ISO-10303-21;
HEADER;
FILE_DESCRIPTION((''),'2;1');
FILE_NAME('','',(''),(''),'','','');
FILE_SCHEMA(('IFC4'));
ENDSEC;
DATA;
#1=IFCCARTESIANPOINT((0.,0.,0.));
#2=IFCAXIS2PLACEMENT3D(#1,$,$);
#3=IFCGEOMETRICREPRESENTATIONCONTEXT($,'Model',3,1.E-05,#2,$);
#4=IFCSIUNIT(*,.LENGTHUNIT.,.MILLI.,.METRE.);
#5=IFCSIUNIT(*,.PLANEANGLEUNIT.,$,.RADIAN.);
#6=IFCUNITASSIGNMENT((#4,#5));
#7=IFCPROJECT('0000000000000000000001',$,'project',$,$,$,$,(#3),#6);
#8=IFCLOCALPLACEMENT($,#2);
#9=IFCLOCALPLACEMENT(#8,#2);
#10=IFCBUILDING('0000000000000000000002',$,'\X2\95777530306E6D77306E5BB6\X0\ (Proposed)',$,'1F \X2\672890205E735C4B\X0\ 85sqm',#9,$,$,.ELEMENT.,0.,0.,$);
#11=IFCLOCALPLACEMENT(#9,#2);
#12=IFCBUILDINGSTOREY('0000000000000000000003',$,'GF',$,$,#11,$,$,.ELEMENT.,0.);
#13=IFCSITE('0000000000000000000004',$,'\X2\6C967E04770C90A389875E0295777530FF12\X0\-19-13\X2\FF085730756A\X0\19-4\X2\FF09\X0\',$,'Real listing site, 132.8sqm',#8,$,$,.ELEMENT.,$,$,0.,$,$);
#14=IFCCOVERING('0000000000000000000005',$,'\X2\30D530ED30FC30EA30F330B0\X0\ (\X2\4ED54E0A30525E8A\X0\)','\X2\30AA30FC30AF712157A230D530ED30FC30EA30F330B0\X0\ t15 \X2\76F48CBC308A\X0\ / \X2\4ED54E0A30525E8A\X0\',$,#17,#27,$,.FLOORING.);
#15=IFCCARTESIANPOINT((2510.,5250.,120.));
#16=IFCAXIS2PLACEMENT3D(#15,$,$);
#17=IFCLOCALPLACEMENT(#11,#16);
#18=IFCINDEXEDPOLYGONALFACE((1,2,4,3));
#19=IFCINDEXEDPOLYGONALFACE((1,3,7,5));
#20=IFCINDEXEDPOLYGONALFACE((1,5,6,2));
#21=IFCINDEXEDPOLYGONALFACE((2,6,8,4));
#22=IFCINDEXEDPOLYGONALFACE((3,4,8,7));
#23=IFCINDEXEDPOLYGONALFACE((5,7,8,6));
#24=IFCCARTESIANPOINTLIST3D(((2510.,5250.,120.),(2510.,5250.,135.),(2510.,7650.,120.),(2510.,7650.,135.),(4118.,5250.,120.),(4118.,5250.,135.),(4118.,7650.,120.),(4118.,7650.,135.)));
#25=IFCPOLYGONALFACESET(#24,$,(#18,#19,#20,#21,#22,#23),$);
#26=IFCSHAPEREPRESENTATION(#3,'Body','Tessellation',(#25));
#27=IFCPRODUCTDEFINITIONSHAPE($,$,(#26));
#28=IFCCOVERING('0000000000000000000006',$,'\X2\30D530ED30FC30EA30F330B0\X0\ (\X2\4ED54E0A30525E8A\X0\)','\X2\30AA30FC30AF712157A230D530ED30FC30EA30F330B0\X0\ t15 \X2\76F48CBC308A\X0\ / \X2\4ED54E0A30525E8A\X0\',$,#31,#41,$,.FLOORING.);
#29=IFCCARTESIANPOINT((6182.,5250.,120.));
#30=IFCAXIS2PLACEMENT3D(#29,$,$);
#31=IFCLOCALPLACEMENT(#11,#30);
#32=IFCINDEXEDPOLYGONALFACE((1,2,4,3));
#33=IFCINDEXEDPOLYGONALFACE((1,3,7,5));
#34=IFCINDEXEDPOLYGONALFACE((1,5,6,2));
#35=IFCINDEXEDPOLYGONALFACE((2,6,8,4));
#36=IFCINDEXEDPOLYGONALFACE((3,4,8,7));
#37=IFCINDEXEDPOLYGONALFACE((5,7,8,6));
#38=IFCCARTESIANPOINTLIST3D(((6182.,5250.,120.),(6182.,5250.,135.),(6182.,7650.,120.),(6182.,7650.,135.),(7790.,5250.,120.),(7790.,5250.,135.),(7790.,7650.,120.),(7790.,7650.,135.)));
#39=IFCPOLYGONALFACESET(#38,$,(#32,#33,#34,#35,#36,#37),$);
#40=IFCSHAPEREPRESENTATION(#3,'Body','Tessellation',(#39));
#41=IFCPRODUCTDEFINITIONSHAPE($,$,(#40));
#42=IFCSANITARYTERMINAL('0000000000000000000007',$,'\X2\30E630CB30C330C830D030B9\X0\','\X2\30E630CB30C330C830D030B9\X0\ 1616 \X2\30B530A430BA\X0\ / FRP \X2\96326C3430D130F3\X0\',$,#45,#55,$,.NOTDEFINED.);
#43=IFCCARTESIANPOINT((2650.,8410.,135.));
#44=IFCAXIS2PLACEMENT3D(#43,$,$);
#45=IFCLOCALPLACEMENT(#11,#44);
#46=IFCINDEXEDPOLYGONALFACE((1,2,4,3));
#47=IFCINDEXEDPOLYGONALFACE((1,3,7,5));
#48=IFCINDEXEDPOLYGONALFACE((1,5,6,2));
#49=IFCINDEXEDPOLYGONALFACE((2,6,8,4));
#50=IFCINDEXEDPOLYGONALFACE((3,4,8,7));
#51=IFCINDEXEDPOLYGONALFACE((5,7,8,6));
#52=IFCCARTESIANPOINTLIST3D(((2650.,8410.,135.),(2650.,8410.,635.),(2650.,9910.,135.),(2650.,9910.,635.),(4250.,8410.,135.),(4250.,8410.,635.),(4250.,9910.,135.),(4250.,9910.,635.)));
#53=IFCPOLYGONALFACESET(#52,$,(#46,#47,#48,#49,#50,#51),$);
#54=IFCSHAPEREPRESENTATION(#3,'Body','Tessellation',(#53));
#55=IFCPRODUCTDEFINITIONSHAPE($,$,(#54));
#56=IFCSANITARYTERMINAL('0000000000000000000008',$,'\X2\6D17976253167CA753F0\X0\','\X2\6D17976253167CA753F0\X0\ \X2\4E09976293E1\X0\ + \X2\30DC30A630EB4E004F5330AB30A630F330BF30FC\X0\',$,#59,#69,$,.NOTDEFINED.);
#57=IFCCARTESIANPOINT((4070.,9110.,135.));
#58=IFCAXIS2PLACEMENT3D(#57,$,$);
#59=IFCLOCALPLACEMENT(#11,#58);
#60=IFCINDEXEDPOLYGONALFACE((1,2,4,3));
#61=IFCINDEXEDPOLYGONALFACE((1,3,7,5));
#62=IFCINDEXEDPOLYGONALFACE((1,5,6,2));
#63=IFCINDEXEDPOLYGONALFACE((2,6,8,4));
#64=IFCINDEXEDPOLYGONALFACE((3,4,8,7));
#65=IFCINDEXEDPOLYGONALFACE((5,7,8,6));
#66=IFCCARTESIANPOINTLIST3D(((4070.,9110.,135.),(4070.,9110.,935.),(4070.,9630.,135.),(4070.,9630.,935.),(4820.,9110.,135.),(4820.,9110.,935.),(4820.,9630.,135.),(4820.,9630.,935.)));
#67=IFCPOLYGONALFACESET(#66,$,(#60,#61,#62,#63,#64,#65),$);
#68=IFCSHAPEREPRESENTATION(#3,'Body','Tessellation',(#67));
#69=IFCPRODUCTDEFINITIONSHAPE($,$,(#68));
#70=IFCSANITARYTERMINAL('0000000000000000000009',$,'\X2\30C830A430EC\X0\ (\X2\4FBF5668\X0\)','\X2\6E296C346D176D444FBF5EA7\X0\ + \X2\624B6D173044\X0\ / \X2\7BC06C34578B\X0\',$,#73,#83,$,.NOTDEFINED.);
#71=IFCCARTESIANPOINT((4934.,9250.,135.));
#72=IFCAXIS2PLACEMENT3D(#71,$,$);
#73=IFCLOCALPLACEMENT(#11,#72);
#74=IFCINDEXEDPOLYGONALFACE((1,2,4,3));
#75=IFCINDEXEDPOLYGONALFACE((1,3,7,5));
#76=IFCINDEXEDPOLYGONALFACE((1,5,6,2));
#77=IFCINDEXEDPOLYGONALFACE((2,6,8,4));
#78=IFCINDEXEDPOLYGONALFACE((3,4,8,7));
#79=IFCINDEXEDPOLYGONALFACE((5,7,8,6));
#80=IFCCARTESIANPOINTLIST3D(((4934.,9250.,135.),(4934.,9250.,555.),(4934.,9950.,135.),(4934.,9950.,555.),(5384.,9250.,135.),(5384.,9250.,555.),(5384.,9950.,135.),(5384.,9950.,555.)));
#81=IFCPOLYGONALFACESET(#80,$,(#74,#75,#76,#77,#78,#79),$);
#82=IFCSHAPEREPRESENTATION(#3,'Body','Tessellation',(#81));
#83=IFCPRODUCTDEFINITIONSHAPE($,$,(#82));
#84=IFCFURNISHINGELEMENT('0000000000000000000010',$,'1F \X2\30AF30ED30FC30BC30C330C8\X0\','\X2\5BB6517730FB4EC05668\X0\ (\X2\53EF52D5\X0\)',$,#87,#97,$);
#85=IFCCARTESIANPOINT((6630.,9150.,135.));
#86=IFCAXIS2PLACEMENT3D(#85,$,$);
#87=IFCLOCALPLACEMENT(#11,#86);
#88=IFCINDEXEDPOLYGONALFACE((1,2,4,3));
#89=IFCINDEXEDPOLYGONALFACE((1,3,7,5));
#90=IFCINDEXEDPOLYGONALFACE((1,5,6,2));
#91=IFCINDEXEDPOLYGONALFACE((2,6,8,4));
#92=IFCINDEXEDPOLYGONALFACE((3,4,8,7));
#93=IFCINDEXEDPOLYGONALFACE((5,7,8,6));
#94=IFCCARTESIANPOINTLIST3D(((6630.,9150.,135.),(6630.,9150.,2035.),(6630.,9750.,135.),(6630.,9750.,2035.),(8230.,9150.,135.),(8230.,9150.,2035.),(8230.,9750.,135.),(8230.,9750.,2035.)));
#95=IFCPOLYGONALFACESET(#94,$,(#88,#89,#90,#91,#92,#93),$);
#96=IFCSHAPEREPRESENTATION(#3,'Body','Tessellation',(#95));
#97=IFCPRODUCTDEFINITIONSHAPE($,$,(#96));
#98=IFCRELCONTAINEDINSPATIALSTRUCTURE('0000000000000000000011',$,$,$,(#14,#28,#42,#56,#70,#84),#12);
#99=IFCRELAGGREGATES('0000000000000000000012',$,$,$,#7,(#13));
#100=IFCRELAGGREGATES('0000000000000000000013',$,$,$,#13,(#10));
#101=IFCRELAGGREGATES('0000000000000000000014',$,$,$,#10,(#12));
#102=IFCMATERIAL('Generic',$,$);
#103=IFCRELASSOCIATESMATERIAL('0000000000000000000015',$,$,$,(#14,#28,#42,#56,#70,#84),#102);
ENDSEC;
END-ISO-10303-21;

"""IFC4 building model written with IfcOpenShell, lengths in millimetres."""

from ifc_helpers import new_model, si_unit, frame, frame_2d, origin, place, context, project, spatial, rectangle, extrude, material, element, save


model = new_model("IFC4")

# Units and contexts
model_context = context("Model", 3, precision=1e-05, world=origin())
ifc_project = project(units=[si_unit("LENGTHUNIT", "METRE", prefix="MILLI"), si_unit("PLANEANGLEUNIT", "RADIAN")], contexts=[model_context])

# Site, building, storey
site_placement = place(None, origin())
site = spatial("IfcSite", under=ifc_project, at=site_placement, Name="沖縄県那覇市長田２-19-13（地番19-4）", ObjectType="Real listing site, 132.8sqm", CompositionType="ELEMENT", RefElevation=0.0)
building_placement = place(site_placement, origin())
building = spatial("IfcBuilding", under=site, at=building_placement, Name="長田の海の家 (Proposed)", ObjectType="1F 木造平屋 85sqm", CompositionType="ELEMENT", ElevationOfRefHeight=0.0, ElevationOfTerrain=0.0)
storey_placement = place(building_placement, origin())
storey = spatial("IfcBuildingStorey", under=building, at=storey_placement, Name="GF", CompositionType="ELEMENT", Elevation=0.0)

# Coverings
ifc_material_1 = material(Name="Generic")
covering_1_placement = place(storey_placement, frame((2510.0, 5250.0, 120.0)))
element("IfcCovering", 1, at=covering_1_placement, inside=storey, material=ifc_material_1, Name="フローリング (仕上げ床)", Description="オーク無垢フローリング t15 直貼り / 仕上げ床", PredefinedType="FLOORING", context=model_context, shape_type="SweptSolid", body=[
    extrude(rectangle(XDim=1608.0, YDim=2400.0, at=frame_2d((804.0, 1200.0))), frame((2510.0, 5250.0, 120.0)), (0.0, 0.0, 1.0), 15.0),
])
covering_2_placement = place(storey_placement, frame((6182.0, 5250.0, 120.0)))
element("IfcCovering", 2, at=covering_2_placement, inside=storey, material=ifc_material_1, Name="フローリング (仕上げ床)", Description="オーク無垢フローリング t15 直貼り / 仕上げ床", PredefinedType="FLOORING", context=model_context, shape_type="SweptSolid", body=[
    extrude(rectangle(XDim=1608.0, YDim=2400.0, at=frame_2d((804.0, 1200.0))), frame((6182.0, 5250.0, 120.0)), (0.0, 0.0, 1.0), 15.0),
])

# Sanitary terminals
sanitary_terminal_1_placement = place(storey_placement, frame((2650.0, 8410.0, 135.0)))
element("IfcSanitaryTerminal", 3, at=sanitary_terminal_1_placement, inside=storey, material=ifc_material_1, Name="ユニットバス", Description="ユニットバス 1616 サイズ / FRP 防水パン", PredefinedType="NOTDEFINED", context=model_context, shape_type="SweptSolid", body=[
    extrude(rectangle(XDim=1600.0, YDim=1500.0, at=frame_2d((800.0, 750.0))), frame((2650.0, 8410.0, 135.0)), (0.0, 0.0, 1.0), 500.0),
])
sanitary_terminal_2_placement = place(storey_placement, frame((4070.0, 9110.0, 135.0)))
element("IfcSanitaryTerminal", 4, at=sanitary_terminal_2_placement, inside=storey, material=ifc_material_1, Name="洗面化粧台", Description="洗面化粧台 三面鏡 + ボウル一体カウンター", PredefinedType="NOTDEFINED", context=model_context, shape_type="SweptSolid", body=[
    extrude(rectangle(XDim=750.0, YDim=520.0, at=frame_2d((375.0, 260.0))), frame((4070.0, 9110.0, 135.0)), (0.0, 0.0, 1.0), 800.0),
])
sanitary_terminal_3_placement = place(storey_placement, frame((4934.0, 9250.0, 135.0)))
element("IfcSanitaryTerminal", 5, at=sanitary_terminal_3_placement, inside=storey, material=ifc_material_1, Name="トイレ (便器)", Description="温水洗浄便座 + 手洗い / 節水型", PredefinedType="NOTDEFINED", context=model_context, shape_type="SweptSolid", body=[
    extrude(rectangle(XDim=450.0, YDim=700.0, at=frame_2d((225.0, 350.0))), frame((4934.0, 9250.0, 135.0)), (0.0, 0.0, 1.0), 420.0),
])

# Furnishing element
furnishing_placement = place(storey_placement, frame((6630.0, 9150.0, 135.0)))
element("IfcFurnishingElement", 6, at=furnishing_placement, inside=storey, material=ifc_material_1, Name="1F クローゼット", Description="家具・什器 (可動)", context=model_context, shape_type="SweptSolid", body=[
    extrude(rectangle(XDim=1600.0, YDim=600.0, at=frame_2d((800.0, 300.0))), frame((6630.0, 9150.0, 135.0)), (0.0, 0.0, 1.0), 1900.0),
])

save(model, "model.ifc")
